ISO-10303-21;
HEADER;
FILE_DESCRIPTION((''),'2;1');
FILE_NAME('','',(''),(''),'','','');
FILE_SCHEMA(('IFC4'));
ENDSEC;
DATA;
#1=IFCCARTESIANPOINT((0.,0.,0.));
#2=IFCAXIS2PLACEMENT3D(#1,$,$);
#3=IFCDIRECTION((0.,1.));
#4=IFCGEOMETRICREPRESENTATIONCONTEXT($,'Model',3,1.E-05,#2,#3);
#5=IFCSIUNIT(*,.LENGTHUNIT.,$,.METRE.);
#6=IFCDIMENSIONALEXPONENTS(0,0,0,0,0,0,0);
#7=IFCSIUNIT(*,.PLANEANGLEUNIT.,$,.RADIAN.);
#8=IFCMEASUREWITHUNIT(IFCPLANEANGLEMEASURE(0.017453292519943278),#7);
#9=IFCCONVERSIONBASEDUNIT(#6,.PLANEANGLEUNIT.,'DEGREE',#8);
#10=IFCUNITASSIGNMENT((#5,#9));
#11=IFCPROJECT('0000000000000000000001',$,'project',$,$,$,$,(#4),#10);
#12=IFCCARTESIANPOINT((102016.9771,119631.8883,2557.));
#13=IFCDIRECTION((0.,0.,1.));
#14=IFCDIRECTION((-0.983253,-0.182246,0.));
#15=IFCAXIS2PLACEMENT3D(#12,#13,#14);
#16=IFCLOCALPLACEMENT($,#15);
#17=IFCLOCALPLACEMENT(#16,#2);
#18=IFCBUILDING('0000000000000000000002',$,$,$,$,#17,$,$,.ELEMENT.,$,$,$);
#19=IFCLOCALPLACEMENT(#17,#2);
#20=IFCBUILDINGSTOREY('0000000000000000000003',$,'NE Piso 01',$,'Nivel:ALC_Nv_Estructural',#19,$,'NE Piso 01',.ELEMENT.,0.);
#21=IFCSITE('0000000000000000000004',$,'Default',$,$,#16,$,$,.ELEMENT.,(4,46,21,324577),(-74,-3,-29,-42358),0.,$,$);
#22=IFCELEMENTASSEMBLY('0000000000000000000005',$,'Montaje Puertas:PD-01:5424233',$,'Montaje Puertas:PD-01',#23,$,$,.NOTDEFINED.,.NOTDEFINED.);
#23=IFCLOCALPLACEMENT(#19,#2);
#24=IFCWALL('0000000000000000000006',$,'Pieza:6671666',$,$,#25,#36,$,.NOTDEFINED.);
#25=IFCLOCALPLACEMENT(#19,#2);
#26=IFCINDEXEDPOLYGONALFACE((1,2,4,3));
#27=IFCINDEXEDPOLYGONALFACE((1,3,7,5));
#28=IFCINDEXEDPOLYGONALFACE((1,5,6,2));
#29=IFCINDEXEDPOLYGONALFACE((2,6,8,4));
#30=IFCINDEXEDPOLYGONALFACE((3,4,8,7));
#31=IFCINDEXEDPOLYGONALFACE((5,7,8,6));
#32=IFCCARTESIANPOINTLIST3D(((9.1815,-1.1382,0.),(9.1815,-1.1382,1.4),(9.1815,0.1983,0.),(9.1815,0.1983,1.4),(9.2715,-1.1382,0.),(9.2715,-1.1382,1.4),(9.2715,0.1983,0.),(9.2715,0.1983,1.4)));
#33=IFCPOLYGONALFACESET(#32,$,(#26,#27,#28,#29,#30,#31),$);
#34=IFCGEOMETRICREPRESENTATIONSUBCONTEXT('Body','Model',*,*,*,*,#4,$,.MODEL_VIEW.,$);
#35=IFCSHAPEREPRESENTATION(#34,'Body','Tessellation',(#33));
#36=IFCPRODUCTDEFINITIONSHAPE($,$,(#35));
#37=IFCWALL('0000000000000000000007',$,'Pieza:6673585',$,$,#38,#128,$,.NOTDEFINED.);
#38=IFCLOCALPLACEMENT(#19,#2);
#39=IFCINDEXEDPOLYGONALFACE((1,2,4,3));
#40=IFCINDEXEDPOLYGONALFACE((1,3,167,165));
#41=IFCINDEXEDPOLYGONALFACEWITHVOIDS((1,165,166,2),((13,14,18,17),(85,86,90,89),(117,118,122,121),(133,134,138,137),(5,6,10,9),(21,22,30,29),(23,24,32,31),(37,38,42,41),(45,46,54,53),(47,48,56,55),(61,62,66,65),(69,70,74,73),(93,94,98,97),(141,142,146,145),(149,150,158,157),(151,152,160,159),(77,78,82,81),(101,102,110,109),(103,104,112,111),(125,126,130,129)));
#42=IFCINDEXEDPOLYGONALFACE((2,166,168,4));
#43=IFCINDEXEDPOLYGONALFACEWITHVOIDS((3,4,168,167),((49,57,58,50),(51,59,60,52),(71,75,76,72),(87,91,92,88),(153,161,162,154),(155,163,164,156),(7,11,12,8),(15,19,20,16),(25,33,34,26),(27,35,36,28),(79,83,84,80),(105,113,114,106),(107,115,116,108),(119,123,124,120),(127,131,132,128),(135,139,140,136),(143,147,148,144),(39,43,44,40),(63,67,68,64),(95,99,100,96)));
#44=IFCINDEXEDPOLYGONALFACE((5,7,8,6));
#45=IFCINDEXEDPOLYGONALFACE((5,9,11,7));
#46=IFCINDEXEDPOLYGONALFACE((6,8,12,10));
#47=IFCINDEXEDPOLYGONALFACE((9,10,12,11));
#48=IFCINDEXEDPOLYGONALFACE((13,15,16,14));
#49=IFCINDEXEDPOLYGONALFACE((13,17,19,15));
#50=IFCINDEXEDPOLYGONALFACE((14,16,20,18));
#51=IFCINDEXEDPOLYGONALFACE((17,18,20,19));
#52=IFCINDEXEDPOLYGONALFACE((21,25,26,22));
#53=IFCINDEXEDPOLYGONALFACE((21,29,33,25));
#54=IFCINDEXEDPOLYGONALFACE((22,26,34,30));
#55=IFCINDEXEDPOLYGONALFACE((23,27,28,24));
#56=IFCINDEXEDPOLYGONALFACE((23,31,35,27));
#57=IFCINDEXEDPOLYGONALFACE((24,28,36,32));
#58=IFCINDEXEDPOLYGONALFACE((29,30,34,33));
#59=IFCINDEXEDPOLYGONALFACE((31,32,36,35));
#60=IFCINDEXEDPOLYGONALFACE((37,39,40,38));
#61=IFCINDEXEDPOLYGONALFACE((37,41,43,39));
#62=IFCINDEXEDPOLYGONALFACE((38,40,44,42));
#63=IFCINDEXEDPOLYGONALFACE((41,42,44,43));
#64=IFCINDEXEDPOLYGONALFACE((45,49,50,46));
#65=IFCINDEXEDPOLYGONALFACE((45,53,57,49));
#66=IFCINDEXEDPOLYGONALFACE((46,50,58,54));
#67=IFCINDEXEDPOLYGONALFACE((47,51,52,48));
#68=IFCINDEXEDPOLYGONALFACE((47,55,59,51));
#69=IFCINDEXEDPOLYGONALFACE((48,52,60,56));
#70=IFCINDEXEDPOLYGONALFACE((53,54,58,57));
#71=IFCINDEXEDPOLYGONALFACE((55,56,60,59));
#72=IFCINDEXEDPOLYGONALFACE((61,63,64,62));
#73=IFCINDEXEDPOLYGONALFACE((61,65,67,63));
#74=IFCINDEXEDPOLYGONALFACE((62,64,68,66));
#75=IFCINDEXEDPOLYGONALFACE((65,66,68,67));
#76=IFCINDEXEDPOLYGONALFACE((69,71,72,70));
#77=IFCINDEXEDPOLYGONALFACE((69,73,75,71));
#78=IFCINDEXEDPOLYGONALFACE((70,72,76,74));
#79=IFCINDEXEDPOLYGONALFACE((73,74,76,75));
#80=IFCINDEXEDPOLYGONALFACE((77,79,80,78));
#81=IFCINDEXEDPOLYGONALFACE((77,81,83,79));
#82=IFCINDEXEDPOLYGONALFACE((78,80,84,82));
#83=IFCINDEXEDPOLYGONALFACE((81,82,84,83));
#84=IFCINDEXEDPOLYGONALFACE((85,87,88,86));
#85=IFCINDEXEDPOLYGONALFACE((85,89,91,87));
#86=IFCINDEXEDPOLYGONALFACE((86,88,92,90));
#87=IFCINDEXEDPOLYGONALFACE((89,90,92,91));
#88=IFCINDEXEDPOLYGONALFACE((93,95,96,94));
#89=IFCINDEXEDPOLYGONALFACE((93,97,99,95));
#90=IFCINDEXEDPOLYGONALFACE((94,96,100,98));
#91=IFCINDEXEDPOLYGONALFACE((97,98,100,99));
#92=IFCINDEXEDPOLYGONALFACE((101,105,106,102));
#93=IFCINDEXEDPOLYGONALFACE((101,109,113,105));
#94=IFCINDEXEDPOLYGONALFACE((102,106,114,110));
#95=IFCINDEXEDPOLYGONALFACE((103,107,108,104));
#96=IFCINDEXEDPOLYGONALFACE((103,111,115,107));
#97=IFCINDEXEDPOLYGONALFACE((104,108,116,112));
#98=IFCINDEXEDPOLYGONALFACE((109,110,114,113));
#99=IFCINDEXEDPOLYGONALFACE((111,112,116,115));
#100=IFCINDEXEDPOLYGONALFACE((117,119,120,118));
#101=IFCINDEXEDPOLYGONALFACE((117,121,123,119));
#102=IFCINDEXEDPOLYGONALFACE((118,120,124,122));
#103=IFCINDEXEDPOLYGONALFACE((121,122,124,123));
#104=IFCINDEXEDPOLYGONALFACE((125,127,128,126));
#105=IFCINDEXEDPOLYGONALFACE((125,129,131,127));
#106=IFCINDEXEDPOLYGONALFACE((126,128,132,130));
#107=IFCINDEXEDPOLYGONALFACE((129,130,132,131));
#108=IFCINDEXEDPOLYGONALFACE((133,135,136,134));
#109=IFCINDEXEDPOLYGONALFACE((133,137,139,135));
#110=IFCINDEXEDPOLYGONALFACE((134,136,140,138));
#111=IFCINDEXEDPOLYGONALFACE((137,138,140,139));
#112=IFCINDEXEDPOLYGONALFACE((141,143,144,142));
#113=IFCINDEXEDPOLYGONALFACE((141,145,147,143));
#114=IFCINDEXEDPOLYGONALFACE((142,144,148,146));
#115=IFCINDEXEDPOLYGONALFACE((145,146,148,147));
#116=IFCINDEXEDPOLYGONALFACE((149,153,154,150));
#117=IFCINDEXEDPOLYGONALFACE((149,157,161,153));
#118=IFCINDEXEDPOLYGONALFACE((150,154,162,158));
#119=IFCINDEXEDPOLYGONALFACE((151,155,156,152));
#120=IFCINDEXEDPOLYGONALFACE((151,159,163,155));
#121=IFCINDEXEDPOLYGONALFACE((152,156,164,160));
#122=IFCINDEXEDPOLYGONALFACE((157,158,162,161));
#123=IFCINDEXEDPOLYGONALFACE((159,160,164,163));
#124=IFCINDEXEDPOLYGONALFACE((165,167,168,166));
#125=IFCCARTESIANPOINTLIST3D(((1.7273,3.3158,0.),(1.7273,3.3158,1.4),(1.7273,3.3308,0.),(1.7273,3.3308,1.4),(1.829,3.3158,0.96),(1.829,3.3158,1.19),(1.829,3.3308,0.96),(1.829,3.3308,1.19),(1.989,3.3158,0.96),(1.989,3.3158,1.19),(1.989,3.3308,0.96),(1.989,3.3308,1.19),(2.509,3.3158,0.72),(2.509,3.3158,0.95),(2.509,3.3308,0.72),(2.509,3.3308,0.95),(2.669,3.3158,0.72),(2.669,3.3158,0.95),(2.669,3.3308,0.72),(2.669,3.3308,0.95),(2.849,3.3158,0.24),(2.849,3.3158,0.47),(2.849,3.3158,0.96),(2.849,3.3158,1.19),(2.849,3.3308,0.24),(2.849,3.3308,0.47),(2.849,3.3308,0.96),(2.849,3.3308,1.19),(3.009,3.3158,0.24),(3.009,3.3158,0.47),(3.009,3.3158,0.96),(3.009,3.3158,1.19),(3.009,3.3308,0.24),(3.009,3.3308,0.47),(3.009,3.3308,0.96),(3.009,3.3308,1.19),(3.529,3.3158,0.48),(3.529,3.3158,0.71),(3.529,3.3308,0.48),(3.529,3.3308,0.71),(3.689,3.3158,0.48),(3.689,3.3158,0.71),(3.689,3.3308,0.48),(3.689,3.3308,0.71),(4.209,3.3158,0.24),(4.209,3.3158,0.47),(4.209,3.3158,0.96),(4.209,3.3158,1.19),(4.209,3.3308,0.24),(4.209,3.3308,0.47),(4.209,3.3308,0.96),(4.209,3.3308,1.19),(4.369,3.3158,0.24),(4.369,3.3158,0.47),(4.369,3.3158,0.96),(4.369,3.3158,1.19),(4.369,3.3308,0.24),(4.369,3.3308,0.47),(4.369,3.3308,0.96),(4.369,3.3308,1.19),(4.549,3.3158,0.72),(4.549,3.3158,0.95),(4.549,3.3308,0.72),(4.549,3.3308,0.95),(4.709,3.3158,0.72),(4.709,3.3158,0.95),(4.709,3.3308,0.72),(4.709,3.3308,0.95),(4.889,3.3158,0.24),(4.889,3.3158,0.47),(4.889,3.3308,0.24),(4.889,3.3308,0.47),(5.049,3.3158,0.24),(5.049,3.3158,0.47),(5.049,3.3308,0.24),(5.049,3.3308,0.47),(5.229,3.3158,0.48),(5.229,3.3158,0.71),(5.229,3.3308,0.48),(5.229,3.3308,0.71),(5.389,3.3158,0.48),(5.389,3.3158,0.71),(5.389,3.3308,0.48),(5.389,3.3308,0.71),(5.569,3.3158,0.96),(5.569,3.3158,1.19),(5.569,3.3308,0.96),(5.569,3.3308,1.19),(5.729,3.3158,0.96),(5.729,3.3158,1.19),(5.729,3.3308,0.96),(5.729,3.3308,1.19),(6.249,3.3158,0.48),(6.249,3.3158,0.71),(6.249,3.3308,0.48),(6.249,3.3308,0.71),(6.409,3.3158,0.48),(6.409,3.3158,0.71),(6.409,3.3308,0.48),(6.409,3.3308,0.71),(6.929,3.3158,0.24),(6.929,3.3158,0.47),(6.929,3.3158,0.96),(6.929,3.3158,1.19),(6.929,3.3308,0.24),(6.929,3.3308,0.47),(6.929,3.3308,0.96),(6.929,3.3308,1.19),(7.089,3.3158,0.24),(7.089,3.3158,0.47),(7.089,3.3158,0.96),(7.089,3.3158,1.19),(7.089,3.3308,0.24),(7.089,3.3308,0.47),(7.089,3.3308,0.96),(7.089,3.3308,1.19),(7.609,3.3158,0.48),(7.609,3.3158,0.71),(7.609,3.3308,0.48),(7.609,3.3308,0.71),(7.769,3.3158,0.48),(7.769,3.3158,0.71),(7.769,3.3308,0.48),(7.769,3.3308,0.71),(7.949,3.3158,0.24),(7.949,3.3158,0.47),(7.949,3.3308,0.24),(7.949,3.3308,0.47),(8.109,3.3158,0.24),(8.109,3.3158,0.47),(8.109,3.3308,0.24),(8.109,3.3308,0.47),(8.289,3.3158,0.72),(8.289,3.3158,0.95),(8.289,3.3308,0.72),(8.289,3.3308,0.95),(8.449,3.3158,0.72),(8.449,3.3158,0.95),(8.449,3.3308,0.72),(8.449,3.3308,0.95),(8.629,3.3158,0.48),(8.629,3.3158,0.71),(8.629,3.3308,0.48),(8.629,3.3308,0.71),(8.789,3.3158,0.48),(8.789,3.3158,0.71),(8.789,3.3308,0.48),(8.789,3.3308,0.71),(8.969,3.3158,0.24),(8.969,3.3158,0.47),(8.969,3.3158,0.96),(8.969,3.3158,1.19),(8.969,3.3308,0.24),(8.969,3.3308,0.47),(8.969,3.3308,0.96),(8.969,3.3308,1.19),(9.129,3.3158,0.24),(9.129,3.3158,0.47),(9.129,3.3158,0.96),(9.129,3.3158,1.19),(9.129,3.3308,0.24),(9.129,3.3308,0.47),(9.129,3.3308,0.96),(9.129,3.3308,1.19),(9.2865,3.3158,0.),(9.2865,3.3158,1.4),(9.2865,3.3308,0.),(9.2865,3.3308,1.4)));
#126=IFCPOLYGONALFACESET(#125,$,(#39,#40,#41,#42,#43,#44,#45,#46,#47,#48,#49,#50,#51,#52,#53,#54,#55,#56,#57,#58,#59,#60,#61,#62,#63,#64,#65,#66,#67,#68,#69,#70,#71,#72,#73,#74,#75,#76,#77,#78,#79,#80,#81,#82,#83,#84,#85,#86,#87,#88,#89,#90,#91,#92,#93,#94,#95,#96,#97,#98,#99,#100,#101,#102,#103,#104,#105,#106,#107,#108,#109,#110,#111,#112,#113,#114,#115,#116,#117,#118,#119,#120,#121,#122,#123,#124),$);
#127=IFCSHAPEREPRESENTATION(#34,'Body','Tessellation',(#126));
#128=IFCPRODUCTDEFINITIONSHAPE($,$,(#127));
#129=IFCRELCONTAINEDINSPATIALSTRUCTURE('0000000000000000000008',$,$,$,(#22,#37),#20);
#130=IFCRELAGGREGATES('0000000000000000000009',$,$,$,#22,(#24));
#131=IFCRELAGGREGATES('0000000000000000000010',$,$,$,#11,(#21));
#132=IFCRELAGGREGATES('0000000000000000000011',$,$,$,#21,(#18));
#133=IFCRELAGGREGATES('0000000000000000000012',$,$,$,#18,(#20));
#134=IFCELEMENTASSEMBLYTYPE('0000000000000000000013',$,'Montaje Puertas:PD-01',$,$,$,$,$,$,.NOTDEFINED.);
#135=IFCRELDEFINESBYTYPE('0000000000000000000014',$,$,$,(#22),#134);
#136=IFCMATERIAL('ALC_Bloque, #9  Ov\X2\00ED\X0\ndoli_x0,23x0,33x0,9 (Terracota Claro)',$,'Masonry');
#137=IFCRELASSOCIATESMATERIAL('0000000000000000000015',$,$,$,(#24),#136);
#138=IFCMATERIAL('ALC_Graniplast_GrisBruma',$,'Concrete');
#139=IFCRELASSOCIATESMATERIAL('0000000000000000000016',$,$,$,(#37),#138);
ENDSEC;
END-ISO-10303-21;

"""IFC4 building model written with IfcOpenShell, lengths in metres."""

from ifc_helpers import new_model, entity, si_unit, converted_unit, direction, frame, frame_2d, origin, place, context, subcontext, project, spatial, rectangle, extrude, boolean, material, type_object, element, aggregate, save


model = new_model("IFC4")

# Units and contexts
model_context = context("Model", 3, precision=1e-05, world=origin(), true_north=direction((0.0, 1.0)))
body_context = subcontext(model_context, "Body", "Model", "MODEL_VIEW")
ifc_project = project(units=[si_unit("LENGTHUNIT", "METRE"), converted_unit("PLANEANGLEUNIT", "DEGREE", entity("IfcPlaneAngleMeasure", 0.017453292519943278), si_unit("PLANEANGLEUNIT", "RADIAN"), dimensions=[0, 0, 0, 0, 0, 0, 0])], contexts=[model_context])

# Site, building, storey
site_placement = place(None, frame((102016.9771, 119631.8883, 2557.0), z_axis=(0.0, 0.0, 1.0), x_axis=(-0.983253, -0.182246, 0.0)))
site = spatial("IfcSite", under=ifc_project, at=site_placement, Name="Default", CompositionType="ELEMENT", RefLatitude=(4, 46, 21, 324577), RefLongitude=(-74, -3, -29, -42358), RefElevation=0.0)
building_placement = place(site_placement, origin())
building = spatial("IfcBuilding", under=site, at=building_placement, CompositionType="ELEMENT")
storey_placement = place(building_placement, origin())
storey = spatial("IfcBuildingStorey", under=building, at=storey_placement, Name="NE Piso 01", ObjectType="Nivel:ALC_Nv_Estructural", LongName="NE Piso 01", CompositionType="ELEMENT", Elevation=0.0)

# Element assembly, wall
element_assembly_type = type_object("IfcElementAssemblyType", Name="Montaje Puertas:PD-01", PredefinedType="NOTDEFINED")
assembly_placement = place(storey_placement, origin())
assembly = element("IfcElementAssembly", 1, at=assembly_placement, inside=storey, type_object=element_assembly_type, Name="Montaje Puertas:PD-01:5424233", ObjectType="Montaje Puertas:PD-01", AssemblyPlace="NOTDEFINED", PredefinedType="NOTDEFINED")
ifc_material_1 = material(Name="ALC_Bloque, #9  Ovíndoli_x0,23x0,33x0,9 (Terracota Claro)", Category="Masonry")
wall_1_placement = place(assembly_placement, origin())
wall_1 = element("IfcWall", 2, at=wall_1_placement, material=ifc_material_1, Name="Pieza:6671666", PredefinedType="NOTDEFINED", context=body_context, shape_type="SweptSolid", body=[
    extrude(rectangle(XDim=1.3365, YDim=0.09, at=frame_2d((0.0, 0.0), x_axis=(1.0, 0.0))), frame((9.2265, -0.4699, 0.0), z_axis=(0.0, 0.0, 1.0), x_axis=(0.0, -1.0, 0.0)), (0.0, 0.0, 1.0), 1.4),
])
aggregate(assembly, [wall_1])

# Wall
ifc_material_2 = material(Name="ALC_Graniplast_GrisBruma", Category="Concrete")
wall_2_placement = place(storey_placement, origin())
solid_1 = boolean("DIFFERENCE", boolean("DIFFERENCE", boolean("DIFFERENCE", boolean("DIFFERENCE", boolean("DIFFERENCE", boolean("DIFFERENCE", boolean("DIFFERENCE", boolean("DIFFERENCE", extrude(rectangle(XDim=0.015, YDim=7.5592, at=frame_2d((0.0, 0.0), x_axis=(1.0, 0.0))), frame((5.5069, 3.3233, 0.0), z_axis=(0.0, 0.0, 1.0), x_axis=(0.0, -1.0, 0.0)), (0.0, 0.0, 1.0), 1.4), extrude(rectangle(XDim=0.23, YDim=0.16, at=frame_2d((0.0, 0.0), x_axis=(0.0, 1.0))), frame((2.929, 3.3308, 0.355), z_axis=(0.0, 1.0, 0.0), x_axis=(1.0, 0.0, 0.0)), (0.0, 0.0, -1.0), 0.015)), extrude(rectangle(XDim=0.23, YDim=0.16, at=frame_2d((0.0, 0.0), x_axis=(0.0, 1.0))), frame((4.289, 3.3308, 0.355), z_axis=(0.0, 1.0, 0.0), x_axis=(1.0, 0.0, 0.0)), (0.0, 0.0, -1.0), 0.015)), extrude(rectangle(XDim=0.23, YDim=0.16, at=frame_2d((0.0, 0.0), x_axis=(0.0, 1.0))), frame((4.969, 3.3308, 0.355), z_axis=(0.0, 1.0, 0.0), x_axis=(1.0, 0.0, 0.0)), (0.0, 0.0, -1.0), 0.015)), extrude(rectangle(XDim=0.23, YDim=0.16, at=frame_2d((0.0, 0.0), x_axis=(0.0, 1.0))), frame((7.009, 3.3308, 0.355), z_axis=(0.0, 1.0, 0.0), x_axis=(1.0, 0.0, 0.0)), (0.0, 0.0, -1.0), 0.015)), extrude(rectangle(XDim=0.23, YDim=0.16, at=frame_2d((0.0, 0.0), x_axis=(0.0, 1.0))), frame((8.029, 3.3308, 0.355), z_axis=(0.0, 1.0, 0.0), x_axis=(1.0, 0.0, 0.0)), (0.0, 0.0, -1.0), 0.015)), extrude(rectangle(XDim=0.23, YDim=0.16, at=frame_2d((0.0, 0.0), x_axis=(0.0, 1.0))), frame((9.049, 3.3308, 0.355), z_axis=(0.0, 1.0, 0.0), x_axis=(1.0, 0.0, 0.0)), (0.0, 0.0, -1.0), 0.015)), extrude(rectangle(XDim=0.23, YDim=0.16, at=frame_2d((0.0, 0.0), x_axis=(0.0, 1.0))), frame((3.609, 3.3308, 0.595), z_axis=(0.0, 1.0, 0.0), x_axis=(1.0, 0.0, 0.0)), (0.0, 0.0, -1.0), 0.015)), extrude(rectangle(XDim=0.23, YDim=0.16, at=frame_2d((0.0, 0.0), x_axis=(0.0, 1.0))), frame((5.309, 3.3308, 0.595), z_axis=(0.0, 1.0, 0.0), x_axis=(1.0, 0.0, 0.0)), (0.0, 0.0, -1.0), 0.015))
solid_2 = boolean("DIFFERENCE", boolean("DIFFERENCE", boolean("DIFFERENCE", boolean("DIFFERENCE", boolean("DIFFERENCE", boolean("DIFFERENCE", boolean("DIFFERENCE", boolean("DIFFERENCE", solid_1, extrude(rectangle(XDim=0.23, YDim=0.16, at=frame_2d((0.0, 0.0), x_axis=(0.0, 1.0))), frame((6.329, 3.3308, 0.595), z_axis=(0.0, 1.0, 0.0), x_axis=(1.0, 0.0, 0.0)), (0.0, 0.0, -1.0), 0.015)), extrude(rectangle(XDim=0.23, YDim=0.16, at=frame_2d((0.0, 0.0), x_axis=(0.0, 1.0))), frame((7.689, 3.3308, 0.595), z_axis=(0.0, 1.0, 0.0), x_axis=(1.0, 0.0, 0.0)), (0.0, 0.0, -1.0), 0.015)), extrude(rectangle(XDim=0.23, YDim=0.16, at=frame_2d((0.0, 0.0), x_axis=(0.0, 1.0))), frame((8.709, 3.3308, 0.595), z_axis=(0.0, 1.0, 0.0), x_axis=(1.0, 0.0, 0.0)), (0.0, 0.0, -1.0), 0.015)), extrude(rectangle(XDim=0.23, YDim=0.16, at=frame_2d((0.0, 0.0), x_axis=(0.0, 1.0))), frame((2.589, 3.3308, 0.835), z_axis=(0.0, 1.0, 0.0), x_axis=(1.0, 0.0, 0.0)), (0.0, 0.0, -1.0), 0.015)), extrude(rectangle(XDim=0.23, YDim=0.16, at=frame_2d((0.0, 0.0), x_axis=(0.0, 1.0))), frame((4.629, 3.3308, 0.835), z_axis=(0.0, 1.0, 0.0), x_axis=(1.0, 0.0, 0.0)), (0.0, 0.0, -1.0), 0.015)), extrude(rectangle(XDim=0.23, YDim=0.16, at=frame_2d((0.0, 0.0), x_axis=(0.0, 1.0))), frame((8.369, 3.3308, 0.835), z_axis=(0.0, 1.0, 0.0), x_axis=(1.0, 0.0, 0.0)), (0.0, 0.0, -1.0), 0.015)), extrude(rectangle(XDim=0.23, YDim=0.16, at=frame_2d((0.0, 0.0), x_axis=(0.0, 1.0))), frame((1.909, 3.3308, 1.075), z_axis=(0.0, 1.0, 0.0), x_axis=(1.0, 0.0, 0.0)), (0.0, 0.0, -1.0), 0.015)), extrude(rectangle(XDim=0.23, YDim=0.16, at=frame_2d((0.0, 0.0), x_axis=(0.0, 1.0))), frame((2.929, 3.3308, 1.075), z_axis=(0.0, 1.0, 0.0), x_axis=(1.0, 0.0, 0.0)), (0.0, 0.0, -1.0), 0.015))
element("IfcWall", 3, at=wall_2_placement, inside=storey, material=ifc_material_2, Name="Pieza:6673585", PredefinedType="NOTDEFINED", context=body_context, shape_type="SweptSolid", body=[
    boolean("DIFFERENCE", boolean("DIFFERENCE", boolean("DIFFERENCE", boolean("DIFFERENCE", solid_2, extrude(rectangle(XDim=0.23, YDim=0.16, at=frame_2d((0.0, 0.0), x_axis=(0.0, 1.0))), frame((4.289, 3.3308, 1.075), z_axis=(0.0, 1.0, 0.0), x_axis=(1.0, 0.0, 0.0)), (0.0, 0.0, -1.0), 0.015)), extrude(rectangle(XDim=0.23, YDim=0.16, at=frame_2d((0.0, 0.0), x_axis=(0.0, 1.0))), frame((5.649, 3.3308, 1.075), z_axis=(0.0, 1.0, 0.0), x_axis=(1.0, 0.0, 0.0)), (0.0, 0.0, -1.0), 0.015)), extrude(rectangle(XDim=0.23, YDim=0.16, at=frame_2d((0.0, 0.0), x_axis=(0.0, 1.0))), frame((7.009, 3.3308, 1.075), z_axis=(0.0, 1.0, 0.0), x_axis=(1.0, 0.0, 0.0)), (0.0, 0.0, -1.0), 0.015)), extrude(rectangle(XDim=0.23, YDim=0.16, at=frame_2d((0.0, 0.0), x_axis=(0.0, 1.0))), frame((9.049, 3.3308, 1.075), z_axis=(0.0, 1.0, 0.0), x_axis=(1.0, 0.0, 0.0)), (0.0, 0.0, -1.0), 0.015)),
])

save(model, "model.ifc")
